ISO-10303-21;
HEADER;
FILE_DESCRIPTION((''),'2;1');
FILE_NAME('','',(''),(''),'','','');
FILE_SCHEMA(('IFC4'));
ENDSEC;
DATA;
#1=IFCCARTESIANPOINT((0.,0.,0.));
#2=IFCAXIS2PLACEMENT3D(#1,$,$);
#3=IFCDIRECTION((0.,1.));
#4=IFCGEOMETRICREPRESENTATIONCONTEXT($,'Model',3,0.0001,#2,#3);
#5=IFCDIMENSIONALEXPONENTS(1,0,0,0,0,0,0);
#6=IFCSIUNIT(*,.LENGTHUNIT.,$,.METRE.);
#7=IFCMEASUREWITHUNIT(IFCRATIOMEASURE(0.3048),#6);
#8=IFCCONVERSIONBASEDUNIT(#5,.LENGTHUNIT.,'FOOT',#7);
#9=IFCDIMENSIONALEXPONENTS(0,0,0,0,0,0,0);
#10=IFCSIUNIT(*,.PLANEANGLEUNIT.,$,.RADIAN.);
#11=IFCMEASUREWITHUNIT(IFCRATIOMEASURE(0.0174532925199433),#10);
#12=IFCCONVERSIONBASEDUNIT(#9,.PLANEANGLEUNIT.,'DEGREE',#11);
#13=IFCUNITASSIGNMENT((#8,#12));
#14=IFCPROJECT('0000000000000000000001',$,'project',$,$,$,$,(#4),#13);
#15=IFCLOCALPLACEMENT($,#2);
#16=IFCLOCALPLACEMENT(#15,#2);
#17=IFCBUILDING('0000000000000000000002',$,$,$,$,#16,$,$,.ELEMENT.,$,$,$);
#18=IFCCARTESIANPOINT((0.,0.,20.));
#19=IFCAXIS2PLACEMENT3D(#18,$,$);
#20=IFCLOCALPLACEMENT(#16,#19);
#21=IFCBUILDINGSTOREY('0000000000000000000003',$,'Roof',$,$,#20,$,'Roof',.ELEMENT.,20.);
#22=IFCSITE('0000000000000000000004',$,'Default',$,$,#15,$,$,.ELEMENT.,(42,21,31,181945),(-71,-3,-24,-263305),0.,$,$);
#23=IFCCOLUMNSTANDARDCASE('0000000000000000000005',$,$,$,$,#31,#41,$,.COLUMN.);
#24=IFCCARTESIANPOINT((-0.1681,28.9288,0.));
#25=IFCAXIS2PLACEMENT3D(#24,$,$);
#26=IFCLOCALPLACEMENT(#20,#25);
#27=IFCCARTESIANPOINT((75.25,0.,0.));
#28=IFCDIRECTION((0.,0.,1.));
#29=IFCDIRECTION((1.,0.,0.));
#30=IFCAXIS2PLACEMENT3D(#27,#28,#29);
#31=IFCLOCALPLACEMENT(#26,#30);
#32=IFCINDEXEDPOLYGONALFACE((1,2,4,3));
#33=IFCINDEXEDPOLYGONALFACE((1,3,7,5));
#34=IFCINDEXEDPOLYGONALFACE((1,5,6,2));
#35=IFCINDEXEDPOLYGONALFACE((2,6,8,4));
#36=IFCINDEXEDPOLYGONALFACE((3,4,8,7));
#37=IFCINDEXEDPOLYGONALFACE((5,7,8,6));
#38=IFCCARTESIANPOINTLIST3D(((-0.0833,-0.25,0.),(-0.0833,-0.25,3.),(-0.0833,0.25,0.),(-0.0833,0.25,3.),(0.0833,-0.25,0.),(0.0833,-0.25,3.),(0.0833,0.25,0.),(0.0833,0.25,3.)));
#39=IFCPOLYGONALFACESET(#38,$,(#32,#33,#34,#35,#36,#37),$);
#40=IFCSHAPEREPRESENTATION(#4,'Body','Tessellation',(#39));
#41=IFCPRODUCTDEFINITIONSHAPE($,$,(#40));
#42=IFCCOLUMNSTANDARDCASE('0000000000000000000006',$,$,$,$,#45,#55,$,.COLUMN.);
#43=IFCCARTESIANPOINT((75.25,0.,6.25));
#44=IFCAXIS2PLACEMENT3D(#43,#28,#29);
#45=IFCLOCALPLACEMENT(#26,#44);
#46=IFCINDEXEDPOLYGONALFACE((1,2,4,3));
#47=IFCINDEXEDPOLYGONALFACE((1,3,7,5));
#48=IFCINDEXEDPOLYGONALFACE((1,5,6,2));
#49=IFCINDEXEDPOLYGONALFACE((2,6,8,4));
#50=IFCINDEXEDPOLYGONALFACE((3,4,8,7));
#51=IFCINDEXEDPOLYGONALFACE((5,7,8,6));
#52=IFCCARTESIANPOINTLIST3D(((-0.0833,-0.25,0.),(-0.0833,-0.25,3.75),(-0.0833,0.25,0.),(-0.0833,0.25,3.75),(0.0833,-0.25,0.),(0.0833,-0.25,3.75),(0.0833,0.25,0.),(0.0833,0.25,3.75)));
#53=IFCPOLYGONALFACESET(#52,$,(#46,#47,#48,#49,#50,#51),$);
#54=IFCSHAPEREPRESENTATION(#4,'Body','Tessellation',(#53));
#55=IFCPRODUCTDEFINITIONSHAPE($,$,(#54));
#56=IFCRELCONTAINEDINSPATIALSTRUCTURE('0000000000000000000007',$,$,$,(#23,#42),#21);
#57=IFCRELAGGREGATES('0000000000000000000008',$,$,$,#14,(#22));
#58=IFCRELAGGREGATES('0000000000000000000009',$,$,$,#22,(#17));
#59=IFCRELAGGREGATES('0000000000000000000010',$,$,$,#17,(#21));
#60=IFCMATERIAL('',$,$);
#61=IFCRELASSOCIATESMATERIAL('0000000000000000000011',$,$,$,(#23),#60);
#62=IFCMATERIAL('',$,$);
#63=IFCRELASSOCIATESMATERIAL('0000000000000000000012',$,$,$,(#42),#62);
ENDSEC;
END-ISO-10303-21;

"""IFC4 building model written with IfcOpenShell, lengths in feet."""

from ifc_helpers import new_model, entity, si_unit, converted_unit, direction, frame, origin, place, context, project, spatial, rectangle, extrude, material, element, save


model = new_model("IFC4")

# Units and contexts
model_context = context("Model", 3, precision=0.0001, world=origin(), true_north=direction((0.0, 1.0)))
ifc_project = project(units=[converted_unit("LENGTHUNIT", "FOOT", entity("IfcRatioMeasure", 0.3048), si_unit("LENGTHUNIT", "METRE"), dimensions=[1, 0, 0, 0, 0, 0, 0]), converted_unit("PLANEANGLEUNIT", "DEGREE", entity("IfcRatioMeasure", 0.0174532925199433), si_unit("PLANEANGLEUNIT", "RADIAN"), dimensions=[0, 0, 0, 0, 0, 0, 0])], contexts=[model_context])

# Site, building, storey
site_placement = place(None, origin())
site = spatial("IfcSite", under=ifc_project, at=site_placement, Name="Default", CompositionType="ELEMENT", RefLatitude=(42, 21, 31, 181945), RefLongitude=(-71, -3, -24, -263305), RefElevation=0.0)
building_placement = place(site_placement, origin())
building = spatial("IfcBuilding", under=site, at=building_placement, CompositionType="ELEMENT")
storey_placement = place(building_placement, frame((0.0, 0.0, 20.0)))
storey = spatial("IfcBuildingStorey", under=building, at=storey_placement, Name="Roof", LongName="Roof", CompositionType="ELEMENT", Elevation=20.0)

# Columns
ifc_material_1 = material(Name="")
placement = place(storey_placement, frame((-0.1681, 28.9288, 0.0)))
for number, where, z_axis, x_axis in (
    (1, (75.25, 0.0, 0.0), (0.0, 0.0, 1.0), (1.0, 0.0, 0.0)),
):
    element("IfcColumnStandardCase", number, at=place(placement, frame(where, z_axis=z_axis, x_axis=x_axis)), inside=storey, material=ifc_material_1, PredefinedType="COLUMN", context=model_context, shape_type="SweptSolid", body=[
        extrude(rectangle(XDim=0.1667, YDim=0.5), origin(), (0.0, 0.0, 1.0), 3.0),
    ])
ifc_material_2 = material(Name="")
for number, where, z_axis, x_axis in (
    (2, (75.25, 0.0, 6.25), (0.0, 0.0, 1.0), (1.0, 0.0, 0.0)),
):
    element("IfcColumnStandardCase", number, at=place(placement, frame(where, z_axis=z_axis, x_axis=x_axis)), inside=storey, material=ifc_material_2, PredefinedType="COLUMN", context=model_context, shape_type="SweptSolid", body=[
        extrude(rectangle(XDim=0.1667, YDim=0.5), origin(), (0.0, 0.0, 1.0), 3.75),
    ])

save(model, "model.ifc")
